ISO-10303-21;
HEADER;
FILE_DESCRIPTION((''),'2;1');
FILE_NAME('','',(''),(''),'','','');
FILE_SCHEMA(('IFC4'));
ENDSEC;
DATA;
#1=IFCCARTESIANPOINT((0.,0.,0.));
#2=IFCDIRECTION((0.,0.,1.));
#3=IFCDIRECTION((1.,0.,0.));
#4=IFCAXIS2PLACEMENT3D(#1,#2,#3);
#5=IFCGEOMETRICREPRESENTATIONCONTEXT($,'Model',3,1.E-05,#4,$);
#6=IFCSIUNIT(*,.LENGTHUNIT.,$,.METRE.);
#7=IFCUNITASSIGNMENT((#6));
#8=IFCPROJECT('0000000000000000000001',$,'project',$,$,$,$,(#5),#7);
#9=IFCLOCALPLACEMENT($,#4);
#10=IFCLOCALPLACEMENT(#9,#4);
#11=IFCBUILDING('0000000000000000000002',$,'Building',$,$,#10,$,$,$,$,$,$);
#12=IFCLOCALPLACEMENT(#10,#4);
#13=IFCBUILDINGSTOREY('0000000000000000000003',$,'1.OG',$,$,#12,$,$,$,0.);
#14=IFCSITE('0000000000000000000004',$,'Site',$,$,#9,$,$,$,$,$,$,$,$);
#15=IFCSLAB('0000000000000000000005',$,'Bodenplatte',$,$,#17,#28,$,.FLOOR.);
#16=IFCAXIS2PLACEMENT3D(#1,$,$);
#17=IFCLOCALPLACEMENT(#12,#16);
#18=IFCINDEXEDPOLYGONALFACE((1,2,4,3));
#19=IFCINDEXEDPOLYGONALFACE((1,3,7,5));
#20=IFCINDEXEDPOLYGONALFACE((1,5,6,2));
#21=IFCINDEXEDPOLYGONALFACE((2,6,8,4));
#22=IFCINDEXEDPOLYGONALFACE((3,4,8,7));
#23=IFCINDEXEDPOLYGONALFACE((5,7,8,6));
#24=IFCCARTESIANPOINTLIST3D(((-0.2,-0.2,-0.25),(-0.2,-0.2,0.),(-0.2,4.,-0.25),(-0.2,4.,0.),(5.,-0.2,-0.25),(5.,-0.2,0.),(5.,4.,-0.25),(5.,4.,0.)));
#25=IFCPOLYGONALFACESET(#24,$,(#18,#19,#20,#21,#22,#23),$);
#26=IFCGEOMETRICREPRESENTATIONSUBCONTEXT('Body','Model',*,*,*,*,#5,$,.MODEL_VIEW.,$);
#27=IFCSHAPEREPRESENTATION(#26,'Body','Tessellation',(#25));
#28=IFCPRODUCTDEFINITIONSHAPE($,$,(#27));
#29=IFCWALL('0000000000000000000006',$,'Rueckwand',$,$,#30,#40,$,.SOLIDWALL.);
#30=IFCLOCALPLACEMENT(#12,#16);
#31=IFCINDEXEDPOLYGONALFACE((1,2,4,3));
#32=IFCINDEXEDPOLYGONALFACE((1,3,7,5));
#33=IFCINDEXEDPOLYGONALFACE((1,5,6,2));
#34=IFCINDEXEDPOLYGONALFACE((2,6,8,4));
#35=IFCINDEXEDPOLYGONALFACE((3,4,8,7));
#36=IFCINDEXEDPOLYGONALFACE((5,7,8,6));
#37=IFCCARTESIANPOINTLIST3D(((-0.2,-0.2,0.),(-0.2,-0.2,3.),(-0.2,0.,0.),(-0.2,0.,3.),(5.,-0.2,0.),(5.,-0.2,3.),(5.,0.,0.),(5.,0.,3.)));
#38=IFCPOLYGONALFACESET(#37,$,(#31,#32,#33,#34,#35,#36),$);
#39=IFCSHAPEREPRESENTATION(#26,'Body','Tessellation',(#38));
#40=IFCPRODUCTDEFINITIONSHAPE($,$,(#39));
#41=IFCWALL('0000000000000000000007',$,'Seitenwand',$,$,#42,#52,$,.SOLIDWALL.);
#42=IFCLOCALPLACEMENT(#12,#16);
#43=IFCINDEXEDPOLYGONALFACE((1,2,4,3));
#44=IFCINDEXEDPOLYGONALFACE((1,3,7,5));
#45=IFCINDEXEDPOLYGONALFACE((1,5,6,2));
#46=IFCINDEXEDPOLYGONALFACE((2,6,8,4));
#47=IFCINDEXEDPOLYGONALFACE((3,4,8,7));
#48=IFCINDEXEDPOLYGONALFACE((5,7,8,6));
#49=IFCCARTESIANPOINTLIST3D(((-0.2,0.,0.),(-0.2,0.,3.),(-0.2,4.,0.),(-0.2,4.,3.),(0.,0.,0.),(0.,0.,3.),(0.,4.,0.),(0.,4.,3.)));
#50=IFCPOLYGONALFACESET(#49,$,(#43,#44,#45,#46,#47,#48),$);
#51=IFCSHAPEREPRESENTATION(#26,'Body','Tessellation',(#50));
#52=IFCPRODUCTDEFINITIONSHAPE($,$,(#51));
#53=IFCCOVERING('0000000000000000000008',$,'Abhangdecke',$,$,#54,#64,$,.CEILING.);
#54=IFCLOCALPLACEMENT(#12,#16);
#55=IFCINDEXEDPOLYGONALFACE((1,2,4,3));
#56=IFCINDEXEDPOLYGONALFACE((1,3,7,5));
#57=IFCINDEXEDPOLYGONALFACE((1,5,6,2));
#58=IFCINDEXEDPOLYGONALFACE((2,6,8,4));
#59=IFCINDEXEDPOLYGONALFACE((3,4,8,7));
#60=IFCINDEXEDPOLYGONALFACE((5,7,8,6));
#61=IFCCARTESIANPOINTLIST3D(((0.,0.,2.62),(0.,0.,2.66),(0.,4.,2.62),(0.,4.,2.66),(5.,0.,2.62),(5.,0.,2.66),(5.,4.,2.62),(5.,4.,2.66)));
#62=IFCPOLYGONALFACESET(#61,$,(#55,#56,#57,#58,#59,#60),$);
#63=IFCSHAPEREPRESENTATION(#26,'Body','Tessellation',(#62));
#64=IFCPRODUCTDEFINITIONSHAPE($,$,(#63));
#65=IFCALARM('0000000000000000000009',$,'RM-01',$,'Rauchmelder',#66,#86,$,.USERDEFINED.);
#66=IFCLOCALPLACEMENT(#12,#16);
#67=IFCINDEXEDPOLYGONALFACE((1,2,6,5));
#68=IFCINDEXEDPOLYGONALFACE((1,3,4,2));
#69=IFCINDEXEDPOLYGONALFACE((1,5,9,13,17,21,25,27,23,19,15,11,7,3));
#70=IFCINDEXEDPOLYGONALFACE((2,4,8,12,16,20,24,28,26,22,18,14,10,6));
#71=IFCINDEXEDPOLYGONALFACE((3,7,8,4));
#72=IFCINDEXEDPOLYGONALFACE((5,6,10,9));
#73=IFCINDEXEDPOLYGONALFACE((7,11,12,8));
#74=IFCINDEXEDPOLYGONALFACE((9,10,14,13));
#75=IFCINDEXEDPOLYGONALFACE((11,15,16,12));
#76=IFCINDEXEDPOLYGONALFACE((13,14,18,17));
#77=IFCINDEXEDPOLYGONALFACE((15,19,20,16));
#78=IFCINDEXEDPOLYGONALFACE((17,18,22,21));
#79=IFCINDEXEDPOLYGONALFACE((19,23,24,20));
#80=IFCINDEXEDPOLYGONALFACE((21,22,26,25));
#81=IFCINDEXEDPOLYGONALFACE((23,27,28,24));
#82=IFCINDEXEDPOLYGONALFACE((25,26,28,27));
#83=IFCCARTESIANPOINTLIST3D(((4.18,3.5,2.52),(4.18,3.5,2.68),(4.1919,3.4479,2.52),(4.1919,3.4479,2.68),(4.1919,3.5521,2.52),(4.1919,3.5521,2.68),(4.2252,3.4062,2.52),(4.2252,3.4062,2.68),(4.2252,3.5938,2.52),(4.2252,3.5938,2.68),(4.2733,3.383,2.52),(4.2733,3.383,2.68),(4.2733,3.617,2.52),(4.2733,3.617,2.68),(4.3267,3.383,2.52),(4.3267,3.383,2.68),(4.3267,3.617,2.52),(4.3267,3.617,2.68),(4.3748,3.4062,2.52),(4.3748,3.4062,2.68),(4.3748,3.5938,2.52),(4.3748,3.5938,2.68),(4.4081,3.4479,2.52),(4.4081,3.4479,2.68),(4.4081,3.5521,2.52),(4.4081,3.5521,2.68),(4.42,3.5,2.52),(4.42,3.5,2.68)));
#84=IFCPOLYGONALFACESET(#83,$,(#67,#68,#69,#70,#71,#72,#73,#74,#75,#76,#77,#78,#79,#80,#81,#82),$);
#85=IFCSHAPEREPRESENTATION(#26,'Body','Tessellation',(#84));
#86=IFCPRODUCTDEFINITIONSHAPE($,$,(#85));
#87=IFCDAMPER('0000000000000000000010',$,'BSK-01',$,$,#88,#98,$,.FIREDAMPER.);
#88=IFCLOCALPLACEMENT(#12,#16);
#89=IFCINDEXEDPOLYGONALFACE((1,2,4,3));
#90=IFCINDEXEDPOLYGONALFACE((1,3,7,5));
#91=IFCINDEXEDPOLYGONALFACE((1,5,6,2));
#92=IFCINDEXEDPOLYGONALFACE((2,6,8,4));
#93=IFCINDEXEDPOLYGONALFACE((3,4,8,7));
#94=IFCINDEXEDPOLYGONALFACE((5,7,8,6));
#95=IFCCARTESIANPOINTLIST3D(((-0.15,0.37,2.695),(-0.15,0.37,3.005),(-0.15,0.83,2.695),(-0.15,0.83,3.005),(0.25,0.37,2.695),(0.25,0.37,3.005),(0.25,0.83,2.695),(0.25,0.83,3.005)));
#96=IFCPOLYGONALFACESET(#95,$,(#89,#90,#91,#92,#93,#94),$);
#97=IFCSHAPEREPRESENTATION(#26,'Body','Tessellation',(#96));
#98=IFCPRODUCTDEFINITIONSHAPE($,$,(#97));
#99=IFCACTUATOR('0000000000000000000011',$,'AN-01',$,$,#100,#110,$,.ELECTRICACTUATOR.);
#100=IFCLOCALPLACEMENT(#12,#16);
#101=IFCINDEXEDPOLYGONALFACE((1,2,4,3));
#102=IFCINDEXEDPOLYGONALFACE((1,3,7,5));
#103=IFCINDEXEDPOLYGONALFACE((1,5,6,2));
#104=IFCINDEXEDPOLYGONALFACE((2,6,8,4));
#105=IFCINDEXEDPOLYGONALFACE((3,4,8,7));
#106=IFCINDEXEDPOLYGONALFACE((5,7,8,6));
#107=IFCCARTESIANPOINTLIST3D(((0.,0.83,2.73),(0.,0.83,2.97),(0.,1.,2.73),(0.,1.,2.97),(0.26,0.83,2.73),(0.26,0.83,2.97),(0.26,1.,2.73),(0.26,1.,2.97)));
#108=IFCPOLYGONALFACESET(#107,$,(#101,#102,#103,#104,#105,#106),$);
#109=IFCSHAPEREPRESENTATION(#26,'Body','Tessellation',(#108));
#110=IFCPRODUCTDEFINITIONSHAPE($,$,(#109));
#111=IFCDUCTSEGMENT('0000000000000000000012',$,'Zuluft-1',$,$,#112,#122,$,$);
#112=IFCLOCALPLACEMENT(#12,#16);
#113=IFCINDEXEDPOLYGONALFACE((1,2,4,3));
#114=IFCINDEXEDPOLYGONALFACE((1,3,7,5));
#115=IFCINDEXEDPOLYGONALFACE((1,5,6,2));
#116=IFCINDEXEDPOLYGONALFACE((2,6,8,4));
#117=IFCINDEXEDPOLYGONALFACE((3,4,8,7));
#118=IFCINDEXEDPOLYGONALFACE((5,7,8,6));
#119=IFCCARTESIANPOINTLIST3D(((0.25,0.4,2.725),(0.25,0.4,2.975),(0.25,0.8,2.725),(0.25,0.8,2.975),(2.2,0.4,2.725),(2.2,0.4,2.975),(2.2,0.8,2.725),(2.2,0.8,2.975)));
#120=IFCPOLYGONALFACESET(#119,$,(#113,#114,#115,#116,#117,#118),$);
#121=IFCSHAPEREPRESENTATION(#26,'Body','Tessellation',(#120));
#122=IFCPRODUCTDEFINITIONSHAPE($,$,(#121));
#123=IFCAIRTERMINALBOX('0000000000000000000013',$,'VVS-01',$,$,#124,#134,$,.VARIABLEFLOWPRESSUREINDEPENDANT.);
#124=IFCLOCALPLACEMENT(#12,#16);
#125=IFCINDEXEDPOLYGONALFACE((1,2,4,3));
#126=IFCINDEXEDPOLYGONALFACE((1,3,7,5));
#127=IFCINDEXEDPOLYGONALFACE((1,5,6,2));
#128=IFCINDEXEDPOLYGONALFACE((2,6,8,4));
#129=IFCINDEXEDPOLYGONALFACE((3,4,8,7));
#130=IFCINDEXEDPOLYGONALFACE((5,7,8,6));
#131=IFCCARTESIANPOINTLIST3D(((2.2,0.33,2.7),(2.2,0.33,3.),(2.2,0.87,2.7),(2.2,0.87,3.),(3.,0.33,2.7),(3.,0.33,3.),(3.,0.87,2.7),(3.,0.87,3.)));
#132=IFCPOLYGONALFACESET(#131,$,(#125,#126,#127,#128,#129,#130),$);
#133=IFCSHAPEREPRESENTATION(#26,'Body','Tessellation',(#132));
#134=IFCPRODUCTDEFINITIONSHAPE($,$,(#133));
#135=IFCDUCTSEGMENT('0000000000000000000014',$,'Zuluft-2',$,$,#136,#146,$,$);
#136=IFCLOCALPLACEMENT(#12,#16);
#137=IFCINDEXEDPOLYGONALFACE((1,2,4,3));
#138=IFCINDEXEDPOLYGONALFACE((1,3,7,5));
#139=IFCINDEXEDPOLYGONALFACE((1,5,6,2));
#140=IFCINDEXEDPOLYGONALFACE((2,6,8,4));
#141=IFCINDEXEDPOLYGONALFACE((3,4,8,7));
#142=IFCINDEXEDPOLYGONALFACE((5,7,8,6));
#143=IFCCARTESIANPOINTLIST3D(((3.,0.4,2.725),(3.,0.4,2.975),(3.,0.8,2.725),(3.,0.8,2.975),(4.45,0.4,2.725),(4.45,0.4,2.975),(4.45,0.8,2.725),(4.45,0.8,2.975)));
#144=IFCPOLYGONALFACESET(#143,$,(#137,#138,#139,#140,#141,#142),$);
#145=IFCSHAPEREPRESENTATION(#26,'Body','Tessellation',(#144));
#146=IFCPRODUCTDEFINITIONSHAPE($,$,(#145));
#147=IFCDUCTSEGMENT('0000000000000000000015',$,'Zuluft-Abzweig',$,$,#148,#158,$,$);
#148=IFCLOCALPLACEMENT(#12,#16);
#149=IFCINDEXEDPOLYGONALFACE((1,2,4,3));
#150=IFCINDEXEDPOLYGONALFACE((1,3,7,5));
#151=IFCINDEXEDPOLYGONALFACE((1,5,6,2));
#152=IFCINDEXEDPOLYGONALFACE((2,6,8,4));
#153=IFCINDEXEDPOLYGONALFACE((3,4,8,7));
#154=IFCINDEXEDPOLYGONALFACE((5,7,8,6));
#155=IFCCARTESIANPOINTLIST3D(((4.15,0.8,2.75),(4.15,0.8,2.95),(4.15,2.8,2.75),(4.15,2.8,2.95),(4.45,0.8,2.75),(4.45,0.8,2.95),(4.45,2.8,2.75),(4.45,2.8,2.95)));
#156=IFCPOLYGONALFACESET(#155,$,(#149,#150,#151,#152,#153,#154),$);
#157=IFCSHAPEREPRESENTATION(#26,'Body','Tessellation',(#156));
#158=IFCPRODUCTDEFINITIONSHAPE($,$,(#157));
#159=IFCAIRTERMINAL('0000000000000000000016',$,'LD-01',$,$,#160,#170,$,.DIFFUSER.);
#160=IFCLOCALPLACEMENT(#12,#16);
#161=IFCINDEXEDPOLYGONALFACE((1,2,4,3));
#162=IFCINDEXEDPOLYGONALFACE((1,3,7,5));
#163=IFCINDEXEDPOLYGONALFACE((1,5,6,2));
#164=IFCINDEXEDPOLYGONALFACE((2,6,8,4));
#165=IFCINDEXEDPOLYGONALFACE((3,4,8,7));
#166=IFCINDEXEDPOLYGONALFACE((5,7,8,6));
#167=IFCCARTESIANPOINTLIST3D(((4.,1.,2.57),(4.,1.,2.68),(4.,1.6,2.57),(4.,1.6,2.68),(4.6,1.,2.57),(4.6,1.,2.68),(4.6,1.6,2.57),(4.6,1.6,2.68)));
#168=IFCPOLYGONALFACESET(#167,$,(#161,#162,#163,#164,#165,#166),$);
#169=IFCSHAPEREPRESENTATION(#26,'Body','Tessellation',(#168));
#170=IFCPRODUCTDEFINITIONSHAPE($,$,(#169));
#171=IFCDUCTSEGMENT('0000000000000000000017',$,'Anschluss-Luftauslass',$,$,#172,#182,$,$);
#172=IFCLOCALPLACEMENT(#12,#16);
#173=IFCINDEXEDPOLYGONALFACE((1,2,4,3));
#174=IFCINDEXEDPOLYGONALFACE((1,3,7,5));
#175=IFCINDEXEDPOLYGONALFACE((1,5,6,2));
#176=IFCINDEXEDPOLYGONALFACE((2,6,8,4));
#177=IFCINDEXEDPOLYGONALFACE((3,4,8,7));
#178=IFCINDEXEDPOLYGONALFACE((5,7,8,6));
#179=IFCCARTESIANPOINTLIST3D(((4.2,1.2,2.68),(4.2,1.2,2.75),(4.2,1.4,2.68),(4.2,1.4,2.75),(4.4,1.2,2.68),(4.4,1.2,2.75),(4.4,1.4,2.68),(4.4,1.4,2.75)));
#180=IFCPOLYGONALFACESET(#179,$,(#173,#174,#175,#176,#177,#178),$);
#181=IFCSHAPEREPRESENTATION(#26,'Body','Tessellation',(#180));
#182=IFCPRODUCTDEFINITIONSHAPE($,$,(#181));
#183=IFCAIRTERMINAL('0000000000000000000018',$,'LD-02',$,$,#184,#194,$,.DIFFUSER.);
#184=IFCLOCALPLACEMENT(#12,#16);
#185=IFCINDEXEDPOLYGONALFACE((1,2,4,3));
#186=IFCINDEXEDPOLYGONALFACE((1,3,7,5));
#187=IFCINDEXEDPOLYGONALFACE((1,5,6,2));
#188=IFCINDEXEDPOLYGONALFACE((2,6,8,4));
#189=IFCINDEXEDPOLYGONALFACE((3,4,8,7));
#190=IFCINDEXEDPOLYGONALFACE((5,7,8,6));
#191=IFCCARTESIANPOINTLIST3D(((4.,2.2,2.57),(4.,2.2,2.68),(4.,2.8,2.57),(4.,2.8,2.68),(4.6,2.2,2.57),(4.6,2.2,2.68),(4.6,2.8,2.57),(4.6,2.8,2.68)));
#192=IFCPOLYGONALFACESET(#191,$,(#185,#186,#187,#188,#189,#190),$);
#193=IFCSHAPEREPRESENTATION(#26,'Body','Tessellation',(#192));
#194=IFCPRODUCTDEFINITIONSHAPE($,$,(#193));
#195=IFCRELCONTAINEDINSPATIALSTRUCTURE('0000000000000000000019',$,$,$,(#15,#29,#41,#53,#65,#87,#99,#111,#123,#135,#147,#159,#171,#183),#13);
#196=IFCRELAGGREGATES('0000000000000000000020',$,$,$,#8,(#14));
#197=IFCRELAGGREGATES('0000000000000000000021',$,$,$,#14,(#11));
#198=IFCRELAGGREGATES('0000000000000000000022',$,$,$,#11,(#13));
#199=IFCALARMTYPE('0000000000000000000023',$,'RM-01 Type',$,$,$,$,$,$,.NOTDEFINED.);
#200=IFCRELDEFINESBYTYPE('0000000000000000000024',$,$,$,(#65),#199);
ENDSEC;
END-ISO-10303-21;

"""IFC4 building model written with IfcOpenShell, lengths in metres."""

from ifc_helpers import new_model, si_unit, frame, origin_with_axes, place, context, subcontext, project, spatial, polyline, outline, extrude, type_object, element, save


model = new_model("IFC4")

# Units and contexts
model_context = context("Model", 3, precision=1e-05, world=origin_with_axes())
body_context = subcontext(model_context, "Body", "Model", "MODEL_VIEW")
ifc_project = project(units=[si_unit("LENGTHUNIT", "METRE")], contexts=[model_context])

# Site, building, storey
site_placement = place(None, origin_with_axes())
site = spatial("IfcSite", under=ifc_project, at=site_placement, Name="Site")
building_placement = place(site_placement, origin_with_axes())
building = spatial("IfcBuilding", under=site, at=building_placement, Name="Building")
storey_placement = place(building_placement, origin_with_axes())
storey = spatial("IfcBuildingStorey", under=building, at=storey_placement, Name="1.OG", Elevation=0.0)

# Slab
slab_placement = place(storey_placement, frame((0.0, 0.0, -0.25), z_axis=(0.0, 0.0, 1.0), x_axis=(1.0, 0.0, 0.0)))
element("IfcSlab", 1, at=slab_placement, inside=storey, Name="Bodenplatte", PredefinedType="FLOOR", context=body_context, shape_type="SweptSolid", body=[
    extrude(outline(polyline([(-0.2, -0.2, 0.0), (5.0, -0.2, 0.0), (5.0, 4.0, 0.0), (-0.2, 4.0, 0.0), (-0.2, -0.2, 0.0)])), origin_with_axes(), (0.0, 0.0, 1.0), 0.25),
])

# Walls
wall_1_placement = place(storey_placement, frame((-0.2, -0.2, 0.0), z_axis=(0.0, 0.0, 1.0), x_axis=(1.0, 0.0, 0.0)))
element("IfcWall", 2, at=wall_1_placement, inside=storey, Name="Rueckwand", PredefinedType="SOLIDWALL", context=body_context, shape_type="SweptSolid", body=[
    extrude(outline(polyline([(0.0, 0.0, 0.0), (5.2, 0.0, 0.0), (5.2, 0.2, 0.0), (0.0, 0.2, 0.0), (0.0, 0.0, 0.0)])), origin_with_axes(), (0.0, 0.0, 1.0), 3.0),
])
wall_2_placement = place(storey_placement, frame((0.0, 0.0, 0.0), z_axis=(0.0, 0.0, 1.0), x_axis=(0.0, 1.0, 0.0)))
element("IfcWall", 3, at=wall_2_placement, inside=storey, Name="Seitenwand", PredefinedType="SOLIDWALL", context=body_context, shape_type="SweptSolid", body=[
    extrude(outline(polyline([(0.0, 0.0, 0.0), (4.0, 0.0, 0.0), (4.0, 0.2, 0.0), (0.0, 0.2, 0.0), (0.0, 0.0, 0.0)])), origin_with_axes(), (0.0, 0.0, 1.0), 3.0),
])

# Covering
covering_placement = place(storey_placement, frame((0.0, 0.0, 2.62), z_axis=(0.0, 0.0, 1.0), x_axis=(1.0, 0.0, 0.0)))
element("IfcCovering", 4, at=covering_placement, inside=storey, Name="Abhangdecke", PredefinedType="CEILING", context=body_context, shape_type="SweptSolid", body=[
    extrude(outline(polyline([(0.0, 0.0, 0.0), (5.0, 0.0, 0.0), (5.0, 4.0, 0.0), (0.0, 4.0, 0.0), (0.0, 0.0, 0.0)])), origin_with_axes(), (0.0, 0.0, 1.0), 0.04),
])

# Alarm
alarm_type = type_object("IfcAlarmType", Name="RM-01 Type", PredefinedType="NOTDEFINED")
alarm_placement = place(storey_placement, origin_with_axes())
element("IfcAlarm", 5, at=alarm_placement, inside=storey, type_object=alarm_type, Name="RM-01", ObjectType="Rauchmelder", PredefinedType="USERDEFINED", context=body_context, shape_type="SweptSolid", body=[
    extrude(outline(polyline([(0.12, 0.0, 0.0), (0.1081, 0.0521, 0.0), (0.0748, 0.0938, 0.0), (0.0267, 0.117, 0.0), (-0.0267, 0.117, 0.0), (-0.0748, 0.0938, 0.0), (-0.1081, 0.0521, 0.0), (-0.12, 0.0, 0.0), (-0.1081, -0.0521, 0.0), (-0.0748, -0.0938, 0.0), (-0.0267, -0.117, 0.0), (0.0267, -0.117, 0.0), (0.0748, -0.0938, 0.0), (0.1081, -0.0521, 0.0), (0.12, 0.0, 0.0)])), frame((4.3, 3.5, 2.52), z_axis=(0.0, 0.0, 1.0), x_axis=(1.0, 0.0, 0.0)), (0.0, 0.0, 1.0), 0.16),
])

# Damper
damper_placement = place(storey_placement, origin_with_axes())
element("IfcDamper", 6, at=damper_placement, inside=storey, Name="BSK-01", PredefinedType="FIREDAMPER", context=body_context, shape_type="SweptSolid", body=[
    extrude(outline(polyline([(-0.15, 0.37, 0.0), (0.25, 0.37, 0.0), (0.25, 0.83, 0.0), (-0.15, 0.83, 0.0), (-0.15, 0.37, 0.0)])), frame((0.0, 0.0, 2.695), z_axis=(0.0, 0.0, 1.0), x_axis=(1.0, 0.0, 0.0)), (0.0, 0.0, 1.0), 0.31),
])

# Actuator
actuator_placement = place(storey_placement, origin_with_axes())
element("IfcActuator", 7, at=actuator_placement, inside=storey, Name="AN-01", PredefinedType="ELECTRICACTUATOR", context=body_context, shape_type="SweptSolid", body=[
    extrude(outline(polyline([(0.0, 0.83, 0.0), (0.26, 0.83, 0.0), (0.26, 1.0, 0.0), (0.0, 1.0, 0.0), (0.0, 0.83, 0.0)])), frame((0.0, 0.0, 2.73), z_axis=(0.0, 0.0, 1.0), x_axis=(1.0, 0.0, 0.0)), (0.0, 0.0, 1.0), 0.24),
])

# Duct segment
duct_segment_1_placement = place(storey_placement, origin_with_axes())
element("IfcDuctSegment", 8, at=duct_segment_1_placement, inside=storey, Name="Zuluft-1", context=body_context, shape_type="SweptSolid", body=[
    extrude(outline(polyline([(-0.2, -0.125, 0.0), (0.2, -0.125, 0.0), (0.2, 0.125, 0.0), (-0.2, 0.125, 0.0), (-0.2, -0.125, 0.0)])), frame((0.25, 0.6, 2.85), z_axis=(1.0, 0.0, 0.0), x_axis=(0.0, 1.0, 0.0)), (0.0, 0.0, 1.0), 1.95),
])

# Air terminal box
air_terminal_box_placement = place(storey_placement, origin_with_axes())
element("IfcAirTerminalBox", 9, at=air_terminal_box_placement, inside=storey, Name="VVS-01", PredefinedType="VARIABLEFLOWPRESSUREINDEPENDANT", context=body_context, shape_type="SweptSolid", body=[
    extrude(outline(polyline([(2.2, 0.33, 0.0), (3.0, 0.33, 0.0), (3.0, 0.87, 0.0), (2.2, 0.87, 0.0), (2.2, 0.33, 0.0)])), frame((0.0, 0.0, 2.7), z_axis=(0.0, 0.0, 1.0), x_axis=(1.0, 0.0, 0.0)), (0.0, 0.0, 1.0), 0.3),
])

# Duct segments
duct_segment_2_placement = place(storey_placement, origin_with_axes())
element("IfcDuctSegment", 10, at=duct_segment_2_placement, inside=storey, Name="Zuluft-2", context=body_context, shape_type="SweptSolid", body=[
    extrude(outline(polyline([(-0.2, -0.125, 0.0), (0.2, -0.125, 0.0), (0.2, 0.125, 0.0), (-0.2, 0.125, 0.0), (-0.2, -0.125, 0.0)])), frame((3.0, 0.6, 2.85), z_axis=(1.0, 0.0, 0.0), x_axis=(0.0, 1.0, 0.0)), (0.0, 0.0, 1.0), 1.45),
])
duct_segment_3_placement = place(storey_placement, origin_with_axes())
element("IfcDuctSegment", 11, at=duct_segment_3_placement, inside=storey, Name="Zuluft-Abzweig", context=body_context, shape_type="SweptSolid", body=[
    extrude(outline(polyline([(-0.15, -0.1, 0.0), (0.15, -0.1, 0.0), (0.15, 0.1, 0.0), (-0.15, 0.1, 0.0), (-0.15, -0.1, 0.0)])), frame((4.3, 0.8, 2.85), z_axis=(0.0, 1.0, 0.0), x_axis=(-1.0, 0.0, 0.0)), (0.0, 0.0, 1.0), 2.0),
])

# Air terminal
air_terminal_1_placement = place(storey_placement, origin_with_axes())
element("IfcAirTerminal", 12, at=air_terminal_1_placement, inside=storey, Name="LD-01", PredefinedType="DIFFUSER", context=body_context, shape_type="SweptSolid", body=[
    extrude(outline(polyline([(4.0, 1.0, 0.0), (4.6, 1.0, 0.0), (4.6, 1.6, 0.0), (4.0, 1.6, 0.0), (4.0, 1.0, 0.0)])), frame((0.0, 0.0, 2.57), z_axis=(0.0, 0.0, 1.0), x_axis=(1.0, 0.0, 0.0)), (0.0, 0.0, 1.0), 0.11),
])

# Duct segment
duct_segment_4_placement = place(storey_placement, origin_with_axes())
element("IfcDuctSegment", 13, at=duct_segment_4_placement, inside=storey, Name="Anschluss-Luftauslass", context=body_context, shape_type="SweptSolid", body=[
    extrude(outline(polyline([(-0.1, -0.1, 0.0), (0.1, -0.1, 0.0), (0.1, 0.1, 0.0), (-0.1, 0.1, 0.0), (-0.1, -0.1, 0.0)])), frame((4.3, 1.3, 2.68), z_axis=(0.0, 0.0, 1.0), x_axis=(1.0, 0.0, 0.0)), (0.0, 0.0, 1.0), 0.07),
])

# Air terminal
air_terminal_2_placement = place(storey_placement, origin_with_axes())
element("IfcAirTerminal", 14, at=air_terminal_2_placement, inside=storey, Name="LD-02", PredefinedType="DIFFUSER", context=body_context, shape_type="SweptSolid", body=[
    extrude(outline(polyline([(4.0, 2.2, 0.0), (4.6, 2.2, 0.0), (4.6, 2.8, 0.0), (4.0, 2.8, 0.0), (4.0, 2.2, 0.0)])), frame((0.0, 0.0, 2.57), z_axis=(0.0, 0.0, 1.0), x_axis=(1.0, 0.0, 0.0)), (0.0, 0.0, 1.0), 0.11),
])

save(model, "model.ifc")
